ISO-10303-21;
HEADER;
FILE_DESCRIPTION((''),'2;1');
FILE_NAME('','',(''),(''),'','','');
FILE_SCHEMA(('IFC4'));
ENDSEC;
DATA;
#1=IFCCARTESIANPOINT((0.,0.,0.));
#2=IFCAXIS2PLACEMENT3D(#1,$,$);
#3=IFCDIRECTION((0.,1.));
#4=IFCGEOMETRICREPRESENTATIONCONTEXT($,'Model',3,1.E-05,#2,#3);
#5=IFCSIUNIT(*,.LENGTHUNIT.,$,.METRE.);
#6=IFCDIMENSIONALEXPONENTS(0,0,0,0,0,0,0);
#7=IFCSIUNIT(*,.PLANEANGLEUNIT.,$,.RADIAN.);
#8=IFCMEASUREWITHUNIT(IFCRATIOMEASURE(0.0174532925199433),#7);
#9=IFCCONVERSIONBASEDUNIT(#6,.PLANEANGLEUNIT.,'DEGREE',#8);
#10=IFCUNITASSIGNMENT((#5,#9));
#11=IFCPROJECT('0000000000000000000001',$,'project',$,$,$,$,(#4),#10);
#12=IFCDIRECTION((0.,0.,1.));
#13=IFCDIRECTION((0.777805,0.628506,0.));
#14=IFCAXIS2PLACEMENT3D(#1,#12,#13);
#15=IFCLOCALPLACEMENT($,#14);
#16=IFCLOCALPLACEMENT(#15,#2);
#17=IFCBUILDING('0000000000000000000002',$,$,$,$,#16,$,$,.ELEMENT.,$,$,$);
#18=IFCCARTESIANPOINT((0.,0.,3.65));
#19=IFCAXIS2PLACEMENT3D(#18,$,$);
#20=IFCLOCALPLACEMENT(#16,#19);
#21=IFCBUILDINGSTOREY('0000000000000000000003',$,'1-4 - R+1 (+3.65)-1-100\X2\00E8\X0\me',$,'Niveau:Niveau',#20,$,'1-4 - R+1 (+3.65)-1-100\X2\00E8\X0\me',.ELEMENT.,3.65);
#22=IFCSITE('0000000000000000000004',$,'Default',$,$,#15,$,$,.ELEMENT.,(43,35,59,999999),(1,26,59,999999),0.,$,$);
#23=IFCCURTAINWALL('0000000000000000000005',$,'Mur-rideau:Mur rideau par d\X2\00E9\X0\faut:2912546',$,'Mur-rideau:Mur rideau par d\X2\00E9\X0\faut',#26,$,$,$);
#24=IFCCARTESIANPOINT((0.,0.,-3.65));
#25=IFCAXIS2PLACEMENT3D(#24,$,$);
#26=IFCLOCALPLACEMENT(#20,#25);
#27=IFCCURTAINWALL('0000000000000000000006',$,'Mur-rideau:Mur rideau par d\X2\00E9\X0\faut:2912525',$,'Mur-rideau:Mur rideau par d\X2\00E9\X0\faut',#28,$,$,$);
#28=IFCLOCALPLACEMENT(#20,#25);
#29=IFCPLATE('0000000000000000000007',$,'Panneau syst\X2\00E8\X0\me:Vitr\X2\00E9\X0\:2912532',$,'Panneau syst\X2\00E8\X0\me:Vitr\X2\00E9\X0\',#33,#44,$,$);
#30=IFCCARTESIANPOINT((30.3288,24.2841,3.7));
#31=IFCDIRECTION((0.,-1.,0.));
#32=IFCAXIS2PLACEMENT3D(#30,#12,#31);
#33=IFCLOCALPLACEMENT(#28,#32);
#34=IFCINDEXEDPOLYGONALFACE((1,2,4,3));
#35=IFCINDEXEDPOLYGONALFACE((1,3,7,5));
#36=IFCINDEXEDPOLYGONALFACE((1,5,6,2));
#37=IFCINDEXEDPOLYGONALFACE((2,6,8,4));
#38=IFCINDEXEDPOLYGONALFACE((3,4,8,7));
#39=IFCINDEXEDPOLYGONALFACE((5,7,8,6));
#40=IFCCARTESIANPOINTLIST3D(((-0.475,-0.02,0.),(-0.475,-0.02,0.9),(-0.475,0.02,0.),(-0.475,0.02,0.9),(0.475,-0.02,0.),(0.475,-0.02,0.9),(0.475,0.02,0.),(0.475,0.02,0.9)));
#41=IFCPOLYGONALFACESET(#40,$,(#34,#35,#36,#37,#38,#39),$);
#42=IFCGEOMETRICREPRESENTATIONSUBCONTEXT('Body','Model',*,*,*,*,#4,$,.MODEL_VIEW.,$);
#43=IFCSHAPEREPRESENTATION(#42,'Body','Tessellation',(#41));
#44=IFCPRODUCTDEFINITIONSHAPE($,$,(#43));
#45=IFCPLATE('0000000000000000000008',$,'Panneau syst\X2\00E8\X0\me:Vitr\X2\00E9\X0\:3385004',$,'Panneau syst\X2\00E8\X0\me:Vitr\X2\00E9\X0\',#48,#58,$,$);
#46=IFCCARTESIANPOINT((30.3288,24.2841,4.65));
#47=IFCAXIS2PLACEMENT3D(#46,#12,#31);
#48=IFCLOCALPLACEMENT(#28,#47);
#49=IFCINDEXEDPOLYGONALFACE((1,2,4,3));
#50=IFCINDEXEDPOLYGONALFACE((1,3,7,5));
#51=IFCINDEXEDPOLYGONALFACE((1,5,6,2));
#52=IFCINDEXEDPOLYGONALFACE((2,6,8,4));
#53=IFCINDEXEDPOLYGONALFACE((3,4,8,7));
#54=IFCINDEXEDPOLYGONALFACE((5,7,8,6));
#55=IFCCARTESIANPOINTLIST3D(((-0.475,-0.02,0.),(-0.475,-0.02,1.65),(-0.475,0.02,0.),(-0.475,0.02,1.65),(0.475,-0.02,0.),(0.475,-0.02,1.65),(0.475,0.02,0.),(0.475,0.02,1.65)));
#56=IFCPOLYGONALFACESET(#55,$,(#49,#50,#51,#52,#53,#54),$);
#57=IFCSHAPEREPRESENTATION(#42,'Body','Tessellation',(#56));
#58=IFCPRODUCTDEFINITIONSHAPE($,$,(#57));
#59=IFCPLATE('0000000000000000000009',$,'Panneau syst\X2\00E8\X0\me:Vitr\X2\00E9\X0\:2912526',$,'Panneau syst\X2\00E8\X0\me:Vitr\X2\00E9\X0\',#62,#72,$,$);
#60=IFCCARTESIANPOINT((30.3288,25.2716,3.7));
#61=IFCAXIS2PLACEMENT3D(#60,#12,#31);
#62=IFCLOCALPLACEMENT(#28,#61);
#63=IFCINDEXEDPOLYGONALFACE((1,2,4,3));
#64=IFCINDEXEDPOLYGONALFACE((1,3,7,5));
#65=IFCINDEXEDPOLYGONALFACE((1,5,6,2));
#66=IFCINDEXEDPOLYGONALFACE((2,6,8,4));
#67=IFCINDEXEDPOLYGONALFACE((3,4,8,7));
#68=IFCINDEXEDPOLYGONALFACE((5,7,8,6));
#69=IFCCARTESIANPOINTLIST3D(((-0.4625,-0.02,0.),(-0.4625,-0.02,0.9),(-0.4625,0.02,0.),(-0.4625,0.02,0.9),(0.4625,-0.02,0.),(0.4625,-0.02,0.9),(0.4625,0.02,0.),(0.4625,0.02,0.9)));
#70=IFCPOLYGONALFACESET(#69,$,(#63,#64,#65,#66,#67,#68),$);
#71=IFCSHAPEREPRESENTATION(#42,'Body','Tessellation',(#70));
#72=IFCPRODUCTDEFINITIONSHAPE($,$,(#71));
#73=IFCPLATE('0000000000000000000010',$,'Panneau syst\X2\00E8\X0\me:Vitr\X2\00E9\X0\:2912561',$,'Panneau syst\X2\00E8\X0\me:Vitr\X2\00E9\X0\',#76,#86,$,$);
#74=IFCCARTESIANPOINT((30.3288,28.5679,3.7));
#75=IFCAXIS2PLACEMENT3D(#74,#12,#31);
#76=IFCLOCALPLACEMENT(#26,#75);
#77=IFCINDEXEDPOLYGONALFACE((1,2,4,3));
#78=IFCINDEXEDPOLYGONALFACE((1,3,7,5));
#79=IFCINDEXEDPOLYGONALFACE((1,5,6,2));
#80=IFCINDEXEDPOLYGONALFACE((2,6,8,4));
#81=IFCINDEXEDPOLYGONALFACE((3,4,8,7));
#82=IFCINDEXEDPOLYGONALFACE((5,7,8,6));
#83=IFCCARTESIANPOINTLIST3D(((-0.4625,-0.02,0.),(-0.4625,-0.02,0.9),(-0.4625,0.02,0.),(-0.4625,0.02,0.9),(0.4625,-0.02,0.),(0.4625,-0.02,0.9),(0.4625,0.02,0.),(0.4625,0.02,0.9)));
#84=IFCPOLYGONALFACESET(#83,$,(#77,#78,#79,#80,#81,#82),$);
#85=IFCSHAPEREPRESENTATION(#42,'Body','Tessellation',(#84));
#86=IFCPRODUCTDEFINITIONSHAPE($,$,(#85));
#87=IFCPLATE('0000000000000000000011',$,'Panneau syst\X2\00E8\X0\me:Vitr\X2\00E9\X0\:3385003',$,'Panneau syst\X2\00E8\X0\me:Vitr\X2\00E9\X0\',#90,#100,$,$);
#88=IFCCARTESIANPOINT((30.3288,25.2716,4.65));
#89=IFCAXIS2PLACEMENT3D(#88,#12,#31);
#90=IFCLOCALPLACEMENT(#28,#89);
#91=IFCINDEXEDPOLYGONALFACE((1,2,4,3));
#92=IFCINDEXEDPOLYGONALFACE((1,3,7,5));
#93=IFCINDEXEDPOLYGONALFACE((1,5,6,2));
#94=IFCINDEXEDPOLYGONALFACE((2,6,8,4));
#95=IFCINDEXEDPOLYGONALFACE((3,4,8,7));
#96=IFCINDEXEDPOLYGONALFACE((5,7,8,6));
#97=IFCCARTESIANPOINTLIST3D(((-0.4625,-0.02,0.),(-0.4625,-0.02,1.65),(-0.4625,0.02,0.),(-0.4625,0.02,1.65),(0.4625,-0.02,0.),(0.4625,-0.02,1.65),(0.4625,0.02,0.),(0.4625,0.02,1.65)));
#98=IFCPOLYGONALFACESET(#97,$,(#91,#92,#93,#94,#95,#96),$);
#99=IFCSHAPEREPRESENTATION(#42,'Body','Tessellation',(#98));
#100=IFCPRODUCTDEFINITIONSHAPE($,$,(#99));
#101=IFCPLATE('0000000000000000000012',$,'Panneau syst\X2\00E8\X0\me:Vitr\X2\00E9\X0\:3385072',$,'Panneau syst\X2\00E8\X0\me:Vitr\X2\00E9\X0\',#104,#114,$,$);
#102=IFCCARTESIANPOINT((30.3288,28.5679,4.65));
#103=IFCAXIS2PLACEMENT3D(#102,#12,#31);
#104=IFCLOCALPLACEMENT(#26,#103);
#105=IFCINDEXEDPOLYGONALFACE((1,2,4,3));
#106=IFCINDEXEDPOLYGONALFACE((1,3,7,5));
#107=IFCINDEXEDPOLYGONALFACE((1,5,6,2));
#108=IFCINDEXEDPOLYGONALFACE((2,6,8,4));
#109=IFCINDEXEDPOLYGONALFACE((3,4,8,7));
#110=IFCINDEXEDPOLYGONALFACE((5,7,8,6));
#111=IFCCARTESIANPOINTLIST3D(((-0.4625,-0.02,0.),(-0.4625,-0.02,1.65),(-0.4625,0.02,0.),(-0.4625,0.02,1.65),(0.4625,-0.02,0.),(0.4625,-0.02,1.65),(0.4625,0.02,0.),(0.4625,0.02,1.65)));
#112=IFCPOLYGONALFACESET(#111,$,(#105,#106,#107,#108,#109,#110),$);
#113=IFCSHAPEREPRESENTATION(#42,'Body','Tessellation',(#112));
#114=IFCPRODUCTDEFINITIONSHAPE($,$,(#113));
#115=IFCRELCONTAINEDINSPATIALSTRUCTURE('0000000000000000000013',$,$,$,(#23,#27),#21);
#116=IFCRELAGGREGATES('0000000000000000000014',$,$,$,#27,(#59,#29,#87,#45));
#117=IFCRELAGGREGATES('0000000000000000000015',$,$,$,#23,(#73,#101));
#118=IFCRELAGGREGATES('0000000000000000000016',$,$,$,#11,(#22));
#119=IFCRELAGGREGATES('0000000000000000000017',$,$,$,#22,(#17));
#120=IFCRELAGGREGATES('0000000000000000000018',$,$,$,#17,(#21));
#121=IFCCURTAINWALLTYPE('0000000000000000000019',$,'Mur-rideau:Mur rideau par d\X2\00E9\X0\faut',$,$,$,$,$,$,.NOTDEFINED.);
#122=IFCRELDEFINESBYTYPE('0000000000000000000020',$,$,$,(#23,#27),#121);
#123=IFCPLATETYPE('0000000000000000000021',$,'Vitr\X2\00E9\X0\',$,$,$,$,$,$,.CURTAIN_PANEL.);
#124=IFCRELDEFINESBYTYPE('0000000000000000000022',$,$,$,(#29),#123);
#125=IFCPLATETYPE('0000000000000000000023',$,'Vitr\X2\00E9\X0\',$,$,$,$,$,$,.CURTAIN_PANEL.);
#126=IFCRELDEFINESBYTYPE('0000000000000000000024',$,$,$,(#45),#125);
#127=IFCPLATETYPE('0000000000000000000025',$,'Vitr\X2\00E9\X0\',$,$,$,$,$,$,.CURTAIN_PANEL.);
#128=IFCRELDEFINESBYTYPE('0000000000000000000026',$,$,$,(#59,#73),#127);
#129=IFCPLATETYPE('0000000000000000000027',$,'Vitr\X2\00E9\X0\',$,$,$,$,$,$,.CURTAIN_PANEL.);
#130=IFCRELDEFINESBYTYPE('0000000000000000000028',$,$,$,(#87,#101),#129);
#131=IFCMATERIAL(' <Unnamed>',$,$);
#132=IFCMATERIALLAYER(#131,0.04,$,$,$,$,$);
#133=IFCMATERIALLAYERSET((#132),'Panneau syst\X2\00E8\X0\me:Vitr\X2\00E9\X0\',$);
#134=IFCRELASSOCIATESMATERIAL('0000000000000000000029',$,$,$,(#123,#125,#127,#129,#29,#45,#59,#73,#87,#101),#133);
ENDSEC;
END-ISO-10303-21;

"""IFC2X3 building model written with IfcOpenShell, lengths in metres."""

from ifc_helpers import new_model, entity, si_unit, converted_unit, direction, frame, frame_2d, origin, origin_2d_with_axis, place, context, subcontext, project, spatial, rectangle, extrude, source, transform, mapped, material, layer, layer_set, layer_usage, type_object, type_shapes, element, aggregate, save


model = new_model("IFC2X3")

# Units and contexts
model_context = context("Model", 3, precision=1e-05, world=origin(), true_north=direction((0.0, 1.0)))
body_context = subcontext(model_context, "Body", "Model", "MODEL_VIEW")
ifc_project = project(units=[si_unit("LENGTHUNIT", "METRE"), converted_unit("PLANEANGLEUNIT", "DEGREE", entity("IfcRatioMeasure", 0.0174532925199433), si_unit("PLANEANGLEUNIT", "RADIAN"), dimensions=[0, 0, 0, 0, 0, 0, 0])], contexts=[model_context])

# Site, building, storey
site_placement = place(None, frame((0.0, 0.0, 0.0), z_axis=(0.0, 0.0, 1.0), x_axis=(0.777805, 0.628506, 0.0)))
site = spatial("IfcSite", under=ifc_project, at=site_placement, Name="Default", CompositionType="ELEMENT", RefLatitude=(43, 35, 59, 999999), RefLongitude=(1, 26, 59, 999999), RefElevation=0.0)
building_placement = place(site_placement, origin())
building = spatial("IfcBuilding", under=site, at=building_placement, CompositionType="ELEMENT")
storey_placement = place(building_placement, frame((0.0, 0.0, 3.65)))
storey = spatial("IfcBuildingStorey", under=building, at=storey_placement, Name="1-4 - R+1 (+3.65)-1-100ème", ObjectType="Niveau:Niveau", LongName="1-4 - R+1 (+3.65)-1-100ème", CompositionType="ELEMENT", Elevation=3.65)

# Curtain wall
curtain_wall_type = type_object("IfcCurtainWallType", Name="Mur-rideau:Mur rideau par défaut", PredefinedType="NOTDEFINED")
curtain_wall_1_placement = place(storey_placement, frame((0.0, 0.0, -3.65)))
curtain_wall_1 = element("IfcCurtainWall", 1, at=curtain_wall_1_placement, inside=storey, type_object=curtain_wall_type, Name="Mur-rideau:Mur rideau par défaut:2912546", ObjectType="Mur-rideau:Mur rideau par défaut")

# Curtain wall
curtain_wall_2_placement = place(storey_placement, frame((0.0, 0.0, -3.65)))
curtain_wall_2 = element("IfcCurtainWall", 2, at=curtain_wall_2_placement, inside=storey, type_object=curtain_wall_type, Name="Mur-rideau:Mur rideau par défaut:2912525", ObjectType="Mur-rideau:Mur rideau par défaut")

# Plates
ifc_material_1 = material(Name=" <Unnamed>")
ifc_layer_1 = layer(ifc_material_1, 0.04)
ifc_layer_set_1 = layer_set([ifc_layer_1], Name="Panneau système:Vitré")
ifc_layer_usage_1 = layer_usage(ifc_layer_set_1, "AXIS3", "POSITIVE", 0.0)
plate_type_1 = type_object("IfcPlateType", Name="Vitré", PredefinedType="CURTAIN_PANEL", material=ifc_layer_set_1)
shared_shape_1 = source(origin(), body_context, "Body", "SweptSolid", [
    extrude(rectangle(XDim=0.04, YDim=0.95, at=frame_2d((0.0, 0.0), x_axis=(1.0, 0.0))), frame((0.0, 0.0, 0.0), z_axis=(0.0, 0.0, 1.0), x_axis=(0.0, 1.0, 0.0)), (0.0, 0.0, 1.0), 0.9),
])
type_shapes(plate_type_1, [shared_shape_1])
plate_1_placement = place(curtain_wall_2_placement, frame((30.3288, 24.2841, 3.7), z_axis=(0.0, 0.0, 1.0), x_axis=(0.0, -1.0, 0.0)))
plate_1 = element("IfcPlate", 3, at=plate_1_placement, type_object=plate_type_1, material=ifc_layer_usage_1, Name="Panneau système:Vitré:2912532", ObjectType="Panneau système:Vitré", context=body_context, shape_type="MappedRepresentation", body=[
    mapped(shared_shape_1, transform((0.0, 0.0, 0.0), scale=1.0)),
])
ifc_layer_usage_2 = layer_usage(ifc_layer_set_1, "AXIS3", "POSITIVE", 0.0)
plate_type_2 = type_object("IfcPlateType", Name="Vitré", PredefinedType="CURTAIN_PANEL", material=ifc_layer_set_1)
shared_shape_2 = source(origin(), body_context, "Body", "SweptSolid", [
    extrude(rectangle(XDim=0.04, YDim=0.95, at=origin_2d_with_axis()), frame((0.0, 0.0, 0.0), z_axis=(0.0, 0.0, 1.0), x_axis=(0.0, 1.0, 0.0)), (0.0, 0.0, 1.0), 1.65),
])
type_shapes(plate_type_2, [shared_shape_2])
plate_2_placement = place(curtain_wall_2_placement, frame((30.3288, 24.2841, 4.65), z_axis=(0.0, 0.0, 1.0), x_axis=(0.0, -1.0, 0.0)))
plate_2 = element("IfcPlate", 4, at=plate_2_placement, type_object=plate_type_2, material=ifc_layer_usage_2, Name="Panneau système:Vitré:3385004", ObjectType="Panneau système:Vitré", context=body_context, shape_type="MappedRepresentation", body=[
    mapped(shared_shape_2, transform((0.0, 0.0, 0.0), scale=1.0)),
])
ifc_layer_usage_3 = layer_usage(ifc_layer_set_1, "AXIS3", "POSITIVE", 0.0)
plate_type_3 = type_object("IfcPlateType", Name="Vitré", PredefinedType="CURTAIN_PANEL", material=ifc_layer_set_1)
shared_shape_3 = source(origin(), body_context, "Body", "SweptSolid", [
    extrude(rectangle(XDim=0.04, YDim=0.925, at=frame_2d((0.0, 0.0), x_axis=(1.0, 0.0))), frame((0.0, 0.0, 0.0), z_axis=(0.0, 0.0, 1.0), x_axis=(0.0, 1.0, 0.0)), (0.0, 0.0, 1.0), 0.9),
])
type_shapes(plate_type_3, [shared_shape_3])
plate_3_placement = place(curtain_wall_2_placement, frame((30.3288, 25.2716, 3.7), z_axis=(0.0, 0.0, 1.0), x_axis=(0.0, -1.0, 0.0)))
plate_3 = element("IfcPlate", 5, at=plate_3_placement, type_object=plate_type_3, material=ifc_layer_usage_3, Name="Panneau système:Vitré:2912526", ObjectType="Panneau système:Vitré", context=body_context, shape_type="MappedRepresentation", body=[
    mapped(shared_shape_3, transform((0.0, 0.0, 0.0), scale=1.0)),
])
ifc_layer_usage_4 = layer_usage(ifc_layer_set_1, "AXIS3", "POSITIVE", 0.0)
plate_4_placement = place(curtain_wall_1_placement, frame((30.3288, 28.5679, 3.7), z_axis=(0.0, 0.0, 1.0), x_axis=(0.0, -1.0, 0.0)))
plate_4 = element("IfcPlate", 6, at=plate_4_placement, type_object=plate_type_3, material=ifc_layer_usage_4, Name="Panneau système:Vitré:2912561", ObjectType="Panneau système:Vitré", context=body_context, shape_type="MappedRepresentation", body=[
    mapped(shared_shape_3, transform((0.0, 0.0, 0.0), scale=1.0)),
])
ifc_layer_usage_5 = layer_usage(ifc_layer_set_1, "AXIS3", "POSITIVE", 0.0)
plate_type_4 = type_object("IfcPlateType", Name="Vitré", PredefinedType="CURTAIN_PANEL", material=ifc_layer_set_1)
shared_shape_4 = source(origin(), body_context, "Body", "SweptSolid", [
    extrude(rectangle(XDim=0.04, YDim=0.925, at=origin_2d_with_axis()), frame((0.0, 0.0, 0.0), z_axis=(0.0, 0.0, 1.0), x_axis=(0.0, 1.0, 0.0)), (0.0, 0.0, 1.0), 1.65),
])
type_shapes(plate_type_4, [shared_shape_4])
plate_5_placement = place(curtain_wall_2_placement, frame((30.3288, 25.2716, 4.65), z_axis=(0.0, 0.0, 1.0), x_axis=(0.0, -1.0, 0.0)))
plate_5 = element("IfcPlate", 7, at=plate_5_placement, type_object=plate_type_4, material=ifc_layer_usage_5, Name="Panneau système:Vitré:3385003", ObjectType="Panneau système:Vitré", context=body_context, shape_type="MappedRepresentation", body=[
    mapped(shared_shape_4, transform((0.0, 0.0, 0.0), scale=1.0)),
])
aggregate(curtain_wall_2, [plate_3, plate_1, plate_5, plate_2])
ifc_layer_usage_6 = layer_usage(ifc_layer_set_1, "AXIS3", "POSITIVE", 0.0)
plate_6_placement = place(curtain_wall_1_placement, frame((30.3288, 28.5679, 4.65), z_axis=(0.0, 0.0, 1.0), x_axis=(0.0, -1.0, 0.0)))
plate_6 = element("IfcPlate", 8, at=plate_6_placement, type_object=plate_type_4, material=ifc_layer_usage_6, Name="Panneau système:Vitré:3385072", ObjectType="Panneau système:Vitré", context=body_context, shape_type="MappedRepresentation", body=[
    mapped(shared_shape_4, transform((0.0, 0.0, 0.0), scale=1.0)),
])
aggregate(curtain_wall_1, [plate_4, plate_6])

save(model, "model.ifc")
